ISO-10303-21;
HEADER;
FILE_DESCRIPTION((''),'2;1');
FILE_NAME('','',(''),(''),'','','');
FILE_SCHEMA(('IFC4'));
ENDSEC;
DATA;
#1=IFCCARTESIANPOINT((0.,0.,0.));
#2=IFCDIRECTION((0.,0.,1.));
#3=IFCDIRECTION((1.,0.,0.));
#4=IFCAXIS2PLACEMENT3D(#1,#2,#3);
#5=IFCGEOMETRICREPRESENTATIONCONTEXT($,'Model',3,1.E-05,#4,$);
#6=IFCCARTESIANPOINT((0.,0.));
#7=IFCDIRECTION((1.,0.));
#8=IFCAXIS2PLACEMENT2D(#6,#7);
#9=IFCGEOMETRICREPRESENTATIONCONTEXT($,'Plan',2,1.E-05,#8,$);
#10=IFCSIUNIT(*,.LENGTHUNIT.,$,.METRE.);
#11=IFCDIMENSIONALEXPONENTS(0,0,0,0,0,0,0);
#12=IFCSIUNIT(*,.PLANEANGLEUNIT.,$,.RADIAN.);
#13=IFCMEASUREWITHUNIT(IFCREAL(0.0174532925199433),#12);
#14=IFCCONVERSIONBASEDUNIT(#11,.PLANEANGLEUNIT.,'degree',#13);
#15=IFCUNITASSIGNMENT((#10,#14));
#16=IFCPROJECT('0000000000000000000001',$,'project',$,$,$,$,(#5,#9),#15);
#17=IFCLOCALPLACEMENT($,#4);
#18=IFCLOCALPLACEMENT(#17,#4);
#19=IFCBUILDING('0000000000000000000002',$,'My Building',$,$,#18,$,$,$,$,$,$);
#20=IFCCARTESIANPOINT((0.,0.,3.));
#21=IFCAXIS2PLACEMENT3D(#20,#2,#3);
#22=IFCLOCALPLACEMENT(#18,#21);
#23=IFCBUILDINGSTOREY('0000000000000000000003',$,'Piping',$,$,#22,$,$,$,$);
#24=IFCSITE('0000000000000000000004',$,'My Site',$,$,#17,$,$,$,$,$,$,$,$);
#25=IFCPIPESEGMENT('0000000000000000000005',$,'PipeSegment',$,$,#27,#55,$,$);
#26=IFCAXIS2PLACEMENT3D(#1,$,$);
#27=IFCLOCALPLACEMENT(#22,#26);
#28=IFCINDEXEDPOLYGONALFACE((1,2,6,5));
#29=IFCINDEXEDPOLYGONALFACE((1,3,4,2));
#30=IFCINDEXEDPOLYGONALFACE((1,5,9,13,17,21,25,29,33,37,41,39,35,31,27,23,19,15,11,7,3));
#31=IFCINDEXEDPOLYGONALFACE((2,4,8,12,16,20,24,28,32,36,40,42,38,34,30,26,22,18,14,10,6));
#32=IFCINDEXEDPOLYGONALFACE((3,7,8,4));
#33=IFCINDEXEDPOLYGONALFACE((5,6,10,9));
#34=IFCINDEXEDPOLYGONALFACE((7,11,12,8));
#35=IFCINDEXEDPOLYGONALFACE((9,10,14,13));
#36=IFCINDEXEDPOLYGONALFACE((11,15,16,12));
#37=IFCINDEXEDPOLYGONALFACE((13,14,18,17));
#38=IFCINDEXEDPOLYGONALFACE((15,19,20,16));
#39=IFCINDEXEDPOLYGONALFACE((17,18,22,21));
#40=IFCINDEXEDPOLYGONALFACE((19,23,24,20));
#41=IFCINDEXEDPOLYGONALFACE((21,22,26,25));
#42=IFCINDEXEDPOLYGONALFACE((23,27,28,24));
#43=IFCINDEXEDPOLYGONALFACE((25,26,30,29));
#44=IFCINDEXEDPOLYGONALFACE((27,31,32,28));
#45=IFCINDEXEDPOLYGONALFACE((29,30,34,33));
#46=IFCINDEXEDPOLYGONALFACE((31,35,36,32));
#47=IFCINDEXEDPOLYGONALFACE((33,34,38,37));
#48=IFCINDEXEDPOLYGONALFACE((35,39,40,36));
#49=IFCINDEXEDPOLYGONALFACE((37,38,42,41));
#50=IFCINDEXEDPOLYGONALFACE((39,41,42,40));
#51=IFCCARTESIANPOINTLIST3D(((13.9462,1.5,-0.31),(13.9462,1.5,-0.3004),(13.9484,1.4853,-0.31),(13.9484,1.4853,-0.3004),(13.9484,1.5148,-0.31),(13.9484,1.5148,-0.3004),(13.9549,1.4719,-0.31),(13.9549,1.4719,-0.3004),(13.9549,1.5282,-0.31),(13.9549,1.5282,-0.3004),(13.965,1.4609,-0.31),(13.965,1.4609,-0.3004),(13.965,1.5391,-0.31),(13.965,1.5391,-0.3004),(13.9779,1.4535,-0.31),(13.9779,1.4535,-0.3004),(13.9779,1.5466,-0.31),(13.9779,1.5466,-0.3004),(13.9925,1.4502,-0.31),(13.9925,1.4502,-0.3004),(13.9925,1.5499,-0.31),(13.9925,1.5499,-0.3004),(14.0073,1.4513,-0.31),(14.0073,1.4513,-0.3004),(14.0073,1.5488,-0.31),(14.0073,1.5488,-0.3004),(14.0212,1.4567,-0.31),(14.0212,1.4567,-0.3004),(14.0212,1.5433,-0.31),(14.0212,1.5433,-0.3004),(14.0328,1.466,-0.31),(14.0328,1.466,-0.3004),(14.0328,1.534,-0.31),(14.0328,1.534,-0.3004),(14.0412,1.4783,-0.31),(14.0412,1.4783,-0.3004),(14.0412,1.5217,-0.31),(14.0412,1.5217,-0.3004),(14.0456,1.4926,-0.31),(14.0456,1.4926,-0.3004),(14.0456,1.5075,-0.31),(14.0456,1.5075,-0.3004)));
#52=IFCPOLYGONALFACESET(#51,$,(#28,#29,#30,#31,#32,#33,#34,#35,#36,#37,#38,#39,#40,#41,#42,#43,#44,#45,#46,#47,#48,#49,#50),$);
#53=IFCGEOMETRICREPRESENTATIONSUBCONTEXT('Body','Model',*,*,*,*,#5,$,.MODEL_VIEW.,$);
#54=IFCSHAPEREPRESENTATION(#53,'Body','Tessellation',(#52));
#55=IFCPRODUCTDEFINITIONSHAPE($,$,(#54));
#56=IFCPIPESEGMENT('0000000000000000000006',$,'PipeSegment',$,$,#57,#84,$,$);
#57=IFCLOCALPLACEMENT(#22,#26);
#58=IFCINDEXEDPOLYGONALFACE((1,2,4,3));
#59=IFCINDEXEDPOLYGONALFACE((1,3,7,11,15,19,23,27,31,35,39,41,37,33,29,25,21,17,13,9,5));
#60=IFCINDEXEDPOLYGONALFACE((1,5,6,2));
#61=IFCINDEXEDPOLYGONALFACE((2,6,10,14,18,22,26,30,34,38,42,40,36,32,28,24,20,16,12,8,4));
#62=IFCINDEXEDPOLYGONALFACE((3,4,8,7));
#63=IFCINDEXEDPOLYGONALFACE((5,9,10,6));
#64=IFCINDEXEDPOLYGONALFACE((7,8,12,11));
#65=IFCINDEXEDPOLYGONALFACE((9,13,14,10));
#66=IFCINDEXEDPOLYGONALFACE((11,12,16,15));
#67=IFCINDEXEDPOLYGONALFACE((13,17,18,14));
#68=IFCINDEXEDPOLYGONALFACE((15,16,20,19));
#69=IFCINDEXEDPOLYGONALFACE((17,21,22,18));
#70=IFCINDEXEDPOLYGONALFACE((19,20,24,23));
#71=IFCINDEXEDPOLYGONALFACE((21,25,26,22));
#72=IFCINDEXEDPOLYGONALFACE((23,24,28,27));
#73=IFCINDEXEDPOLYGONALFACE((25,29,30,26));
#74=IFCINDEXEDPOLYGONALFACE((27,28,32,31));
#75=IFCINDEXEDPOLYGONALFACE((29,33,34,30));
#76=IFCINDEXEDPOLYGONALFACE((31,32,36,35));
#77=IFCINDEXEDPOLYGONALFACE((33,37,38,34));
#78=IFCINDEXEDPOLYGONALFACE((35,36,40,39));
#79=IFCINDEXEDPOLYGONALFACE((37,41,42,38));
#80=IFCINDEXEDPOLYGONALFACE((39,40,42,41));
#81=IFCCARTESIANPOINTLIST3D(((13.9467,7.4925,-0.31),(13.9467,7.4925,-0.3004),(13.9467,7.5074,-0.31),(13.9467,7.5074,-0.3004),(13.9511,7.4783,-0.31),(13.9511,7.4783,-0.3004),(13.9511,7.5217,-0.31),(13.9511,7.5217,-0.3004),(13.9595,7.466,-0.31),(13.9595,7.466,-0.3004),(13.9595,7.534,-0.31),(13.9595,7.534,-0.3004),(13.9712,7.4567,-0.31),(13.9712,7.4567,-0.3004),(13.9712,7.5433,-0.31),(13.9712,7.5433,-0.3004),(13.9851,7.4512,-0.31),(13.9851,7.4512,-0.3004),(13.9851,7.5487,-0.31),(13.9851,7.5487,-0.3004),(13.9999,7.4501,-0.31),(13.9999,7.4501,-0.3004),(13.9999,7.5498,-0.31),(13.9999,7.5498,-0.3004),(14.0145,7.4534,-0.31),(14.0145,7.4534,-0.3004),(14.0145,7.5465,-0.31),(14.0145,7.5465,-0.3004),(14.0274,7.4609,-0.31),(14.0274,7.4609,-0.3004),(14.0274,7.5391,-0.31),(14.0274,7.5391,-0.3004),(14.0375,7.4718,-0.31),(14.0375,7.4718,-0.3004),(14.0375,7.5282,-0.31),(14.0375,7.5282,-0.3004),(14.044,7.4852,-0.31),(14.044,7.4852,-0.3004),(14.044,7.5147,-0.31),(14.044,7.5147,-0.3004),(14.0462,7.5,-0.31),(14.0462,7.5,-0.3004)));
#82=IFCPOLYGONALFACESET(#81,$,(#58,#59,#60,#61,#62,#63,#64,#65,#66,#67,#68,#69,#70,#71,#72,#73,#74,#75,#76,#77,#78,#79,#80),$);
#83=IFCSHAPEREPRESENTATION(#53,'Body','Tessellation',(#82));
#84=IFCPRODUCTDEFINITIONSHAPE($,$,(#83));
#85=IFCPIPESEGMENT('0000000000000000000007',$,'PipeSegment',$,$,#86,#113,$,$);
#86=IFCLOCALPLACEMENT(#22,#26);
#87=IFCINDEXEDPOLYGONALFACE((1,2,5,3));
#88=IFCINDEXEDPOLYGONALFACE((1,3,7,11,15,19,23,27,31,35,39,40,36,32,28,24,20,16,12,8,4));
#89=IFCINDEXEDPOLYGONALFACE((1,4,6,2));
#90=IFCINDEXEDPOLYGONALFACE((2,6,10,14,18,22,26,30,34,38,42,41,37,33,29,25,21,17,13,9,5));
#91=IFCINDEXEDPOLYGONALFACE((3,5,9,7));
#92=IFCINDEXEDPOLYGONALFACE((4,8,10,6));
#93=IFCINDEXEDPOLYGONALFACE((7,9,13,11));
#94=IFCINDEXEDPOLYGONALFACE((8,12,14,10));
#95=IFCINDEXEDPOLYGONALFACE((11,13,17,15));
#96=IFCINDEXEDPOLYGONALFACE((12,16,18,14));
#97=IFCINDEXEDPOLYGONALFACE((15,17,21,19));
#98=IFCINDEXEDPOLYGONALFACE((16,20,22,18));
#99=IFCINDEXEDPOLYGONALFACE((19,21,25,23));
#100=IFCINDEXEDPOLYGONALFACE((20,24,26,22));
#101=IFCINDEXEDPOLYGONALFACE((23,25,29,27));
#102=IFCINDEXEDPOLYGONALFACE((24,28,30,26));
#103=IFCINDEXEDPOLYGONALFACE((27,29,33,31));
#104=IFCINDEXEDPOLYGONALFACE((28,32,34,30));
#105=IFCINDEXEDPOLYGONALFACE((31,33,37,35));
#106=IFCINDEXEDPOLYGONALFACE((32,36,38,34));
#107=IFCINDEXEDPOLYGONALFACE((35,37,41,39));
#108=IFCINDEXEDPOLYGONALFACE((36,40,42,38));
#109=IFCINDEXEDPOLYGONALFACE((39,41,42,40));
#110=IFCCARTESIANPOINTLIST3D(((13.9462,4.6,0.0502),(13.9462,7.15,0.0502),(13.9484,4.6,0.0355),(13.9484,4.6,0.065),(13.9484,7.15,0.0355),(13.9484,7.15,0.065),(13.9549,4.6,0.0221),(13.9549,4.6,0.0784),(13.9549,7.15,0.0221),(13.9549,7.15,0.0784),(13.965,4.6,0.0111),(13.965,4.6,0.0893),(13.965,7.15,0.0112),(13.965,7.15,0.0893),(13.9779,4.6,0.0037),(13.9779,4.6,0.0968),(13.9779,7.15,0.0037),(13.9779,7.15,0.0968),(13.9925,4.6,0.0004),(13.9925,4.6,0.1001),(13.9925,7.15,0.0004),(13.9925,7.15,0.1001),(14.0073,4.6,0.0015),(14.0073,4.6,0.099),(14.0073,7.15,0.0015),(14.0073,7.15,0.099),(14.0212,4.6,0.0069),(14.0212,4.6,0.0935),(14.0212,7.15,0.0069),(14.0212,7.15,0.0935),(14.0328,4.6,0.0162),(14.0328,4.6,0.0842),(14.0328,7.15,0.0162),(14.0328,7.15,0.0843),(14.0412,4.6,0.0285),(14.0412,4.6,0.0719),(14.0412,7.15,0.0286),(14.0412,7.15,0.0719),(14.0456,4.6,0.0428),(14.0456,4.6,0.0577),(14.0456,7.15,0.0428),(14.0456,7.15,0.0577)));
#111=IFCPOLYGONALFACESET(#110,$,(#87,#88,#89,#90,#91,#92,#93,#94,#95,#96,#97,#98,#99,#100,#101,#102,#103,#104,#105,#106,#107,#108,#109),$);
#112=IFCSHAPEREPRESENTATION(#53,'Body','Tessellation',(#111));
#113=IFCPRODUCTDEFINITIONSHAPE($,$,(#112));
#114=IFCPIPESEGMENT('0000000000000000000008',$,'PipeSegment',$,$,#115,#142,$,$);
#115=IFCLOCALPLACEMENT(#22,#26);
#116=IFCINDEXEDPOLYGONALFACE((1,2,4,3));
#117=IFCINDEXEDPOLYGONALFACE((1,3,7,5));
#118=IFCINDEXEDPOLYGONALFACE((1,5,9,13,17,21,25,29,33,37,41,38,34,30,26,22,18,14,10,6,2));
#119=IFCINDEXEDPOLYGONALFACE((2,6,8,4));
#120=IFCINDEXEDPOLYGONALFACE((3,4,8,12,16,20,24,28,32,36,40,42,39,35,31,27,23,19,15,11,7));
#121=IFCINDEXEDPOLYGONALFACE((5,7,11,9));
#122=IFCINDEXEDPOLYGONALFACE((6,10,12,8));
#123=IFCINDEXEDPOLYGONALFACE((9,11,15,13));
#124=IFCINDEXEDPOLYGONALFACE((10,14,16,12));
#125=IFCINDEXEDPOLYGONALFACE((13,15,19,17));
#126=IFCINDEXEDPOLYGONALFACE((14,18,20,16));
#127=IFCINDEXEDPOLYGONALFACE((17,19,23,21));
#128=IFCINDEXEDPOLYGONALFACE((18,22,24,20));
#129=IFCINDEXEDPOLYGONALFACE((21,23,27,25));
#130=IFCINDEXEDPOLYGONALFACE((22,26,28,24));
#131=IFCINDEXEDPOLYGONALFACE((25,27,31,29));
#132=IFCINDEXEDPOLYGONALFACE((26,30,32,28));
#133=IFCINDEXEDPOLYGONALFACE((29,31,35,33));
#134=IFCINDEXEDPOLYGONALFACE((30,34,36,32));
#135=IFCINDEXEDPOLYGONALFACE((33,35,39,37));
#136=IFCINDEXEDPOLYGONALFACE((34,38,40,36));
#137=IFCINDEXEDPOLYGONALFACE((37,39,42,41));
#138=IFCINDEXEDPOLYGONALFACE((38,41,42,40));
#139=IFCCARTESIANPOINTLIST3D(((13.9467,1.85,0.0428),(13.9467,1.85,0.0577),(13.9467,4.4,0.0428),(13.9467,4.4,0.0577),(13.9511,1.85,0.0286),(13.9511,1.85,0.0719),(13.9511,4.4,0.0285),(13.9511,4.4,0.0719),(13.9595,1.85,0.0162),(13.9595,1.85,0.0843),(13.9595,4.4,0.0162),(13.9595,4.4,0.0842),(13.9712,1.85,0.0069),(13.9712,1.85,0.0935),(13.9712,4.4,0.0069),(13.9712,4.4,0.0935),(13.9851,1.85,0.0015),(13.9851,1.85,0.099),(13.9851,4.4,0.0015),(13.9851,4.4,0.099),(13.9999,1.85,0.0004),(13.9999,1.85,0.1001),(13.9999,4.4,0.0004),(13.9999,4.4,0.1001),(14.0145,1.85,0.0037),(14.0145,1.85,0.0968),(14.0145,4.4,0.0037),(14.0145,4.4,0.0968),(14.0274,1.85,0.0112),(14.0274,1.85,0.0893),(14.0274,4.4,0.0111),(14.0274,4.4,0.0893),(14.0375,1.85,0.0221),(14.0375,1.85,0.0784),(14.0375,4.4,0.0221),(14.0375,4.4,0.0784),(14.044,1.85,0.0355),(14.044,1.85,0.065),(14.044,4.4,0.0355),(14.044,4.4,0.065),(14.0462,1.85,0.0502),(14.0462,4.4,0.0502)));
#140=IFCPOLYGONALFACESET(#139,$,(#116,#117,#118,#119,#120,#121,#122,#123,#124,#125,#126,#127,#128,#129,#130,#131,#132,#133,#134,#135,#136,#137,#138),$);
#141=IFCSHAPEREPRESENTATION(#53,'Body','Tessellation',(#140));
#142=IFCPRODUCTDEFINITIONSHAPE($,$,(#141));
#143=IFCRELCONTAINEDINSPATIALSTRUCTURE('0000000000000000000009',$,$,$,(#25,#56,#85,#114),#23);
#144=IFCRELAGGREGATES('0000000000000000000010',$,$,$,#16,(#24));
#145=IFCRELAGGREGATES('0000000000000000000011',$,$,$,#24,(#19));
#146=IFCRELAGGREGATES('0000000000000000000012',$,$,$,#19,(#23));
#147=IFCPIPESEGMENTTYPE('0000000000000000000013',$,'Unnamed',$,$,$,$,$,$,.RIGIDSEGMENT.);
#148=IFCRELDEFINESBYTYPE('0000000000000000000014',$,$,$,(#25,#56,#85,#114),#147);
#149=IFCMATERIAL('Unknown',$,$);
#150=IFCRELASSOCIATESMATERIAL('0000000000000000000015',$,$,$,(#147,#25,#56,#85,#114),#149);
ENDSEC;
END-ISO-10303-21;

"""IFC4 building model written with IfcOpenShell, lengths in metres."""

from ifc_helpers import new_model, entity, si_unit, converted_unit, frame, origin_with_axes, origin_2d_with_axis, place, context, subcontext, project, spatial, circle, extrude, material, material_profile, profile_set, profile_usage, type_object, element, save


model = new_model("IFC4")

# Units and contexts
model_context = context("Model", 3, precision=1e-05, world=origin_with_axes())
plan_context = context("Plan", 2, precision=1e-05, world=origin_2d_with_axis())
body_context = subcontext(model_context, "Body", "Model", "MODEL_VIEW")
ifc_project = project(units=[si_unit("LENGTHUNIT", "METRE"), converted_unit("PLANEANGLEUNIT", "degree", entity("IfcReal", 0.0174532925199433), si_unit("PLANEANGLEUNIT", "RADIAN"), dimensions=[0, 0, 0, 0, 0, 0, 0])], contexts=[model_context, plan_context])

# Site, building, storey
site_placement = place(None, origin_with_axes())
site = spatial("IfcSite", under=ifc_project, at=site_placement, Name="My Site")
building_placement = place(site_placement, origin_with_axes())
building = spatial("IfcBuilding", under=site, at=building_placement, Name="My Building")
storey_placement = place(building_placement, frame((0.0, 0.0, 3.0), z_axis=(0.0, 0.0, 1.0), x_axis=(1.0, 0.0, 0.0)))
storey = spatial("IfcBuildingStorey", under=building, at=storey_placement, Name="Piping")

# Pipe segments
ifc_material = material(Name="Unknown")
ifc_material_profile_1 = material_profile(ifc_material, circle(Radius=0.05))
ifc_profile_set_1 = profile_set([ifc_material_profile_1])
pipe_segment_type = type_object("IfcPipeSegmentType", Name="Unnamed", PredefinedType="RIGIDSEGMENT", material=ifc_profile_set_1)
ifc_profile_usage_1 = profile_usage(ifc_profile_set_1, cardinal=16)
pipe_segment_1_placement = place(storey_placement, frame((13.9962, 1.5, -0.3004), z_axis=(0.0, 0.0, -1.0), x_axis=(-1.0, 0.0, 0.0)))
element("IfcPipeSegment", 1, at=pipe_segment_1_placement, inside=storey, type_object=pipe_segment_type, material=ifc_profile_usage_1, Name="PipeSegment", context=body_context, shape_type="SweptSolid", body=[
    extrude(circle(Radius=0.05), origin_with_axes(), (0.0, 0.0, 1.0), 0.0096),
])
ifc_profile_usage_2 = profile_usage(ifc_profile_set_1, cardinal=16)
pipe_segment_2_placement = place(storey_placement, frame((13.9962, 7.5, -0.3004), z_axis=(0.0, 0.0, -1.0), x_axis=(1.0, 0.0, 0.0)))
element("IfcPipeSegment", 2, at=pipe_segment_2_placement, inside=storey, type_object=pipe_segment_type, material=ifc_profile_usage_2, Name="PipeSegment", context=body_context, shape_type="SweptSolid", body=[
    extrude(circle(Radius=0.05), origin_with_axes(), (0.0, 0.0, 1.0), 0.0096),
])
ifc_profile_usage_3 = profile_usage(ifc_profile_set_1, cardinal=2)
pipe_segment_3_placement = place(storey_placement, frame((13.9962, 4.6, 0.0002), z_axis=(0.0, 1.0, 0.000006), x_axis=(-1.0, 0.0, 0.0)))
element("IfcPipeSegment", 3, at=pipe_segment_3_placement, inside=storey, type_object=pipe_segment_type, material=ifc_profile_usage_3, Name="PipeSegment", context=body_context, shape_type="SweptSolid", body=[
    extrude(circle(Radius=0.05), frame((0.0, 0.05, 0.0), z_axis=(0.0, 0.0, 1.0), x_axis=(1.0, 0.0, 0.0)), (0.0, 0.0, 1.0), 2.55),
])
ifc_profile_usage_4 = profile_usage(ifc_profile_set_1, cardinal=2)
pipe_segment_4_placement = place(storey_placement, frame((13.9962, 4.4, 0.0002), z_axis=(0.0, -1.0, 0.000006), x_axis=(1.0, 0.0, 0.0)))
element("IfcPipeSegment", 4, at=pipe_segment_4_placement, inside=storey, type_object=pipe_segment_type, material=ifc_profile_usage_4, Name="PipeSegment", context=body_context, shape_type="SweptSolid", body=[
    extrude(circle(Radius=0.05), frame((0.0, 0.05, 0.0), z_axis=(0.0, 0.0, 1.0), x_axis=(1.0, 0.0, 0.0)), (0.0, 0.0, 1.0), 2.55),
])

save(model, "model.ifc")
